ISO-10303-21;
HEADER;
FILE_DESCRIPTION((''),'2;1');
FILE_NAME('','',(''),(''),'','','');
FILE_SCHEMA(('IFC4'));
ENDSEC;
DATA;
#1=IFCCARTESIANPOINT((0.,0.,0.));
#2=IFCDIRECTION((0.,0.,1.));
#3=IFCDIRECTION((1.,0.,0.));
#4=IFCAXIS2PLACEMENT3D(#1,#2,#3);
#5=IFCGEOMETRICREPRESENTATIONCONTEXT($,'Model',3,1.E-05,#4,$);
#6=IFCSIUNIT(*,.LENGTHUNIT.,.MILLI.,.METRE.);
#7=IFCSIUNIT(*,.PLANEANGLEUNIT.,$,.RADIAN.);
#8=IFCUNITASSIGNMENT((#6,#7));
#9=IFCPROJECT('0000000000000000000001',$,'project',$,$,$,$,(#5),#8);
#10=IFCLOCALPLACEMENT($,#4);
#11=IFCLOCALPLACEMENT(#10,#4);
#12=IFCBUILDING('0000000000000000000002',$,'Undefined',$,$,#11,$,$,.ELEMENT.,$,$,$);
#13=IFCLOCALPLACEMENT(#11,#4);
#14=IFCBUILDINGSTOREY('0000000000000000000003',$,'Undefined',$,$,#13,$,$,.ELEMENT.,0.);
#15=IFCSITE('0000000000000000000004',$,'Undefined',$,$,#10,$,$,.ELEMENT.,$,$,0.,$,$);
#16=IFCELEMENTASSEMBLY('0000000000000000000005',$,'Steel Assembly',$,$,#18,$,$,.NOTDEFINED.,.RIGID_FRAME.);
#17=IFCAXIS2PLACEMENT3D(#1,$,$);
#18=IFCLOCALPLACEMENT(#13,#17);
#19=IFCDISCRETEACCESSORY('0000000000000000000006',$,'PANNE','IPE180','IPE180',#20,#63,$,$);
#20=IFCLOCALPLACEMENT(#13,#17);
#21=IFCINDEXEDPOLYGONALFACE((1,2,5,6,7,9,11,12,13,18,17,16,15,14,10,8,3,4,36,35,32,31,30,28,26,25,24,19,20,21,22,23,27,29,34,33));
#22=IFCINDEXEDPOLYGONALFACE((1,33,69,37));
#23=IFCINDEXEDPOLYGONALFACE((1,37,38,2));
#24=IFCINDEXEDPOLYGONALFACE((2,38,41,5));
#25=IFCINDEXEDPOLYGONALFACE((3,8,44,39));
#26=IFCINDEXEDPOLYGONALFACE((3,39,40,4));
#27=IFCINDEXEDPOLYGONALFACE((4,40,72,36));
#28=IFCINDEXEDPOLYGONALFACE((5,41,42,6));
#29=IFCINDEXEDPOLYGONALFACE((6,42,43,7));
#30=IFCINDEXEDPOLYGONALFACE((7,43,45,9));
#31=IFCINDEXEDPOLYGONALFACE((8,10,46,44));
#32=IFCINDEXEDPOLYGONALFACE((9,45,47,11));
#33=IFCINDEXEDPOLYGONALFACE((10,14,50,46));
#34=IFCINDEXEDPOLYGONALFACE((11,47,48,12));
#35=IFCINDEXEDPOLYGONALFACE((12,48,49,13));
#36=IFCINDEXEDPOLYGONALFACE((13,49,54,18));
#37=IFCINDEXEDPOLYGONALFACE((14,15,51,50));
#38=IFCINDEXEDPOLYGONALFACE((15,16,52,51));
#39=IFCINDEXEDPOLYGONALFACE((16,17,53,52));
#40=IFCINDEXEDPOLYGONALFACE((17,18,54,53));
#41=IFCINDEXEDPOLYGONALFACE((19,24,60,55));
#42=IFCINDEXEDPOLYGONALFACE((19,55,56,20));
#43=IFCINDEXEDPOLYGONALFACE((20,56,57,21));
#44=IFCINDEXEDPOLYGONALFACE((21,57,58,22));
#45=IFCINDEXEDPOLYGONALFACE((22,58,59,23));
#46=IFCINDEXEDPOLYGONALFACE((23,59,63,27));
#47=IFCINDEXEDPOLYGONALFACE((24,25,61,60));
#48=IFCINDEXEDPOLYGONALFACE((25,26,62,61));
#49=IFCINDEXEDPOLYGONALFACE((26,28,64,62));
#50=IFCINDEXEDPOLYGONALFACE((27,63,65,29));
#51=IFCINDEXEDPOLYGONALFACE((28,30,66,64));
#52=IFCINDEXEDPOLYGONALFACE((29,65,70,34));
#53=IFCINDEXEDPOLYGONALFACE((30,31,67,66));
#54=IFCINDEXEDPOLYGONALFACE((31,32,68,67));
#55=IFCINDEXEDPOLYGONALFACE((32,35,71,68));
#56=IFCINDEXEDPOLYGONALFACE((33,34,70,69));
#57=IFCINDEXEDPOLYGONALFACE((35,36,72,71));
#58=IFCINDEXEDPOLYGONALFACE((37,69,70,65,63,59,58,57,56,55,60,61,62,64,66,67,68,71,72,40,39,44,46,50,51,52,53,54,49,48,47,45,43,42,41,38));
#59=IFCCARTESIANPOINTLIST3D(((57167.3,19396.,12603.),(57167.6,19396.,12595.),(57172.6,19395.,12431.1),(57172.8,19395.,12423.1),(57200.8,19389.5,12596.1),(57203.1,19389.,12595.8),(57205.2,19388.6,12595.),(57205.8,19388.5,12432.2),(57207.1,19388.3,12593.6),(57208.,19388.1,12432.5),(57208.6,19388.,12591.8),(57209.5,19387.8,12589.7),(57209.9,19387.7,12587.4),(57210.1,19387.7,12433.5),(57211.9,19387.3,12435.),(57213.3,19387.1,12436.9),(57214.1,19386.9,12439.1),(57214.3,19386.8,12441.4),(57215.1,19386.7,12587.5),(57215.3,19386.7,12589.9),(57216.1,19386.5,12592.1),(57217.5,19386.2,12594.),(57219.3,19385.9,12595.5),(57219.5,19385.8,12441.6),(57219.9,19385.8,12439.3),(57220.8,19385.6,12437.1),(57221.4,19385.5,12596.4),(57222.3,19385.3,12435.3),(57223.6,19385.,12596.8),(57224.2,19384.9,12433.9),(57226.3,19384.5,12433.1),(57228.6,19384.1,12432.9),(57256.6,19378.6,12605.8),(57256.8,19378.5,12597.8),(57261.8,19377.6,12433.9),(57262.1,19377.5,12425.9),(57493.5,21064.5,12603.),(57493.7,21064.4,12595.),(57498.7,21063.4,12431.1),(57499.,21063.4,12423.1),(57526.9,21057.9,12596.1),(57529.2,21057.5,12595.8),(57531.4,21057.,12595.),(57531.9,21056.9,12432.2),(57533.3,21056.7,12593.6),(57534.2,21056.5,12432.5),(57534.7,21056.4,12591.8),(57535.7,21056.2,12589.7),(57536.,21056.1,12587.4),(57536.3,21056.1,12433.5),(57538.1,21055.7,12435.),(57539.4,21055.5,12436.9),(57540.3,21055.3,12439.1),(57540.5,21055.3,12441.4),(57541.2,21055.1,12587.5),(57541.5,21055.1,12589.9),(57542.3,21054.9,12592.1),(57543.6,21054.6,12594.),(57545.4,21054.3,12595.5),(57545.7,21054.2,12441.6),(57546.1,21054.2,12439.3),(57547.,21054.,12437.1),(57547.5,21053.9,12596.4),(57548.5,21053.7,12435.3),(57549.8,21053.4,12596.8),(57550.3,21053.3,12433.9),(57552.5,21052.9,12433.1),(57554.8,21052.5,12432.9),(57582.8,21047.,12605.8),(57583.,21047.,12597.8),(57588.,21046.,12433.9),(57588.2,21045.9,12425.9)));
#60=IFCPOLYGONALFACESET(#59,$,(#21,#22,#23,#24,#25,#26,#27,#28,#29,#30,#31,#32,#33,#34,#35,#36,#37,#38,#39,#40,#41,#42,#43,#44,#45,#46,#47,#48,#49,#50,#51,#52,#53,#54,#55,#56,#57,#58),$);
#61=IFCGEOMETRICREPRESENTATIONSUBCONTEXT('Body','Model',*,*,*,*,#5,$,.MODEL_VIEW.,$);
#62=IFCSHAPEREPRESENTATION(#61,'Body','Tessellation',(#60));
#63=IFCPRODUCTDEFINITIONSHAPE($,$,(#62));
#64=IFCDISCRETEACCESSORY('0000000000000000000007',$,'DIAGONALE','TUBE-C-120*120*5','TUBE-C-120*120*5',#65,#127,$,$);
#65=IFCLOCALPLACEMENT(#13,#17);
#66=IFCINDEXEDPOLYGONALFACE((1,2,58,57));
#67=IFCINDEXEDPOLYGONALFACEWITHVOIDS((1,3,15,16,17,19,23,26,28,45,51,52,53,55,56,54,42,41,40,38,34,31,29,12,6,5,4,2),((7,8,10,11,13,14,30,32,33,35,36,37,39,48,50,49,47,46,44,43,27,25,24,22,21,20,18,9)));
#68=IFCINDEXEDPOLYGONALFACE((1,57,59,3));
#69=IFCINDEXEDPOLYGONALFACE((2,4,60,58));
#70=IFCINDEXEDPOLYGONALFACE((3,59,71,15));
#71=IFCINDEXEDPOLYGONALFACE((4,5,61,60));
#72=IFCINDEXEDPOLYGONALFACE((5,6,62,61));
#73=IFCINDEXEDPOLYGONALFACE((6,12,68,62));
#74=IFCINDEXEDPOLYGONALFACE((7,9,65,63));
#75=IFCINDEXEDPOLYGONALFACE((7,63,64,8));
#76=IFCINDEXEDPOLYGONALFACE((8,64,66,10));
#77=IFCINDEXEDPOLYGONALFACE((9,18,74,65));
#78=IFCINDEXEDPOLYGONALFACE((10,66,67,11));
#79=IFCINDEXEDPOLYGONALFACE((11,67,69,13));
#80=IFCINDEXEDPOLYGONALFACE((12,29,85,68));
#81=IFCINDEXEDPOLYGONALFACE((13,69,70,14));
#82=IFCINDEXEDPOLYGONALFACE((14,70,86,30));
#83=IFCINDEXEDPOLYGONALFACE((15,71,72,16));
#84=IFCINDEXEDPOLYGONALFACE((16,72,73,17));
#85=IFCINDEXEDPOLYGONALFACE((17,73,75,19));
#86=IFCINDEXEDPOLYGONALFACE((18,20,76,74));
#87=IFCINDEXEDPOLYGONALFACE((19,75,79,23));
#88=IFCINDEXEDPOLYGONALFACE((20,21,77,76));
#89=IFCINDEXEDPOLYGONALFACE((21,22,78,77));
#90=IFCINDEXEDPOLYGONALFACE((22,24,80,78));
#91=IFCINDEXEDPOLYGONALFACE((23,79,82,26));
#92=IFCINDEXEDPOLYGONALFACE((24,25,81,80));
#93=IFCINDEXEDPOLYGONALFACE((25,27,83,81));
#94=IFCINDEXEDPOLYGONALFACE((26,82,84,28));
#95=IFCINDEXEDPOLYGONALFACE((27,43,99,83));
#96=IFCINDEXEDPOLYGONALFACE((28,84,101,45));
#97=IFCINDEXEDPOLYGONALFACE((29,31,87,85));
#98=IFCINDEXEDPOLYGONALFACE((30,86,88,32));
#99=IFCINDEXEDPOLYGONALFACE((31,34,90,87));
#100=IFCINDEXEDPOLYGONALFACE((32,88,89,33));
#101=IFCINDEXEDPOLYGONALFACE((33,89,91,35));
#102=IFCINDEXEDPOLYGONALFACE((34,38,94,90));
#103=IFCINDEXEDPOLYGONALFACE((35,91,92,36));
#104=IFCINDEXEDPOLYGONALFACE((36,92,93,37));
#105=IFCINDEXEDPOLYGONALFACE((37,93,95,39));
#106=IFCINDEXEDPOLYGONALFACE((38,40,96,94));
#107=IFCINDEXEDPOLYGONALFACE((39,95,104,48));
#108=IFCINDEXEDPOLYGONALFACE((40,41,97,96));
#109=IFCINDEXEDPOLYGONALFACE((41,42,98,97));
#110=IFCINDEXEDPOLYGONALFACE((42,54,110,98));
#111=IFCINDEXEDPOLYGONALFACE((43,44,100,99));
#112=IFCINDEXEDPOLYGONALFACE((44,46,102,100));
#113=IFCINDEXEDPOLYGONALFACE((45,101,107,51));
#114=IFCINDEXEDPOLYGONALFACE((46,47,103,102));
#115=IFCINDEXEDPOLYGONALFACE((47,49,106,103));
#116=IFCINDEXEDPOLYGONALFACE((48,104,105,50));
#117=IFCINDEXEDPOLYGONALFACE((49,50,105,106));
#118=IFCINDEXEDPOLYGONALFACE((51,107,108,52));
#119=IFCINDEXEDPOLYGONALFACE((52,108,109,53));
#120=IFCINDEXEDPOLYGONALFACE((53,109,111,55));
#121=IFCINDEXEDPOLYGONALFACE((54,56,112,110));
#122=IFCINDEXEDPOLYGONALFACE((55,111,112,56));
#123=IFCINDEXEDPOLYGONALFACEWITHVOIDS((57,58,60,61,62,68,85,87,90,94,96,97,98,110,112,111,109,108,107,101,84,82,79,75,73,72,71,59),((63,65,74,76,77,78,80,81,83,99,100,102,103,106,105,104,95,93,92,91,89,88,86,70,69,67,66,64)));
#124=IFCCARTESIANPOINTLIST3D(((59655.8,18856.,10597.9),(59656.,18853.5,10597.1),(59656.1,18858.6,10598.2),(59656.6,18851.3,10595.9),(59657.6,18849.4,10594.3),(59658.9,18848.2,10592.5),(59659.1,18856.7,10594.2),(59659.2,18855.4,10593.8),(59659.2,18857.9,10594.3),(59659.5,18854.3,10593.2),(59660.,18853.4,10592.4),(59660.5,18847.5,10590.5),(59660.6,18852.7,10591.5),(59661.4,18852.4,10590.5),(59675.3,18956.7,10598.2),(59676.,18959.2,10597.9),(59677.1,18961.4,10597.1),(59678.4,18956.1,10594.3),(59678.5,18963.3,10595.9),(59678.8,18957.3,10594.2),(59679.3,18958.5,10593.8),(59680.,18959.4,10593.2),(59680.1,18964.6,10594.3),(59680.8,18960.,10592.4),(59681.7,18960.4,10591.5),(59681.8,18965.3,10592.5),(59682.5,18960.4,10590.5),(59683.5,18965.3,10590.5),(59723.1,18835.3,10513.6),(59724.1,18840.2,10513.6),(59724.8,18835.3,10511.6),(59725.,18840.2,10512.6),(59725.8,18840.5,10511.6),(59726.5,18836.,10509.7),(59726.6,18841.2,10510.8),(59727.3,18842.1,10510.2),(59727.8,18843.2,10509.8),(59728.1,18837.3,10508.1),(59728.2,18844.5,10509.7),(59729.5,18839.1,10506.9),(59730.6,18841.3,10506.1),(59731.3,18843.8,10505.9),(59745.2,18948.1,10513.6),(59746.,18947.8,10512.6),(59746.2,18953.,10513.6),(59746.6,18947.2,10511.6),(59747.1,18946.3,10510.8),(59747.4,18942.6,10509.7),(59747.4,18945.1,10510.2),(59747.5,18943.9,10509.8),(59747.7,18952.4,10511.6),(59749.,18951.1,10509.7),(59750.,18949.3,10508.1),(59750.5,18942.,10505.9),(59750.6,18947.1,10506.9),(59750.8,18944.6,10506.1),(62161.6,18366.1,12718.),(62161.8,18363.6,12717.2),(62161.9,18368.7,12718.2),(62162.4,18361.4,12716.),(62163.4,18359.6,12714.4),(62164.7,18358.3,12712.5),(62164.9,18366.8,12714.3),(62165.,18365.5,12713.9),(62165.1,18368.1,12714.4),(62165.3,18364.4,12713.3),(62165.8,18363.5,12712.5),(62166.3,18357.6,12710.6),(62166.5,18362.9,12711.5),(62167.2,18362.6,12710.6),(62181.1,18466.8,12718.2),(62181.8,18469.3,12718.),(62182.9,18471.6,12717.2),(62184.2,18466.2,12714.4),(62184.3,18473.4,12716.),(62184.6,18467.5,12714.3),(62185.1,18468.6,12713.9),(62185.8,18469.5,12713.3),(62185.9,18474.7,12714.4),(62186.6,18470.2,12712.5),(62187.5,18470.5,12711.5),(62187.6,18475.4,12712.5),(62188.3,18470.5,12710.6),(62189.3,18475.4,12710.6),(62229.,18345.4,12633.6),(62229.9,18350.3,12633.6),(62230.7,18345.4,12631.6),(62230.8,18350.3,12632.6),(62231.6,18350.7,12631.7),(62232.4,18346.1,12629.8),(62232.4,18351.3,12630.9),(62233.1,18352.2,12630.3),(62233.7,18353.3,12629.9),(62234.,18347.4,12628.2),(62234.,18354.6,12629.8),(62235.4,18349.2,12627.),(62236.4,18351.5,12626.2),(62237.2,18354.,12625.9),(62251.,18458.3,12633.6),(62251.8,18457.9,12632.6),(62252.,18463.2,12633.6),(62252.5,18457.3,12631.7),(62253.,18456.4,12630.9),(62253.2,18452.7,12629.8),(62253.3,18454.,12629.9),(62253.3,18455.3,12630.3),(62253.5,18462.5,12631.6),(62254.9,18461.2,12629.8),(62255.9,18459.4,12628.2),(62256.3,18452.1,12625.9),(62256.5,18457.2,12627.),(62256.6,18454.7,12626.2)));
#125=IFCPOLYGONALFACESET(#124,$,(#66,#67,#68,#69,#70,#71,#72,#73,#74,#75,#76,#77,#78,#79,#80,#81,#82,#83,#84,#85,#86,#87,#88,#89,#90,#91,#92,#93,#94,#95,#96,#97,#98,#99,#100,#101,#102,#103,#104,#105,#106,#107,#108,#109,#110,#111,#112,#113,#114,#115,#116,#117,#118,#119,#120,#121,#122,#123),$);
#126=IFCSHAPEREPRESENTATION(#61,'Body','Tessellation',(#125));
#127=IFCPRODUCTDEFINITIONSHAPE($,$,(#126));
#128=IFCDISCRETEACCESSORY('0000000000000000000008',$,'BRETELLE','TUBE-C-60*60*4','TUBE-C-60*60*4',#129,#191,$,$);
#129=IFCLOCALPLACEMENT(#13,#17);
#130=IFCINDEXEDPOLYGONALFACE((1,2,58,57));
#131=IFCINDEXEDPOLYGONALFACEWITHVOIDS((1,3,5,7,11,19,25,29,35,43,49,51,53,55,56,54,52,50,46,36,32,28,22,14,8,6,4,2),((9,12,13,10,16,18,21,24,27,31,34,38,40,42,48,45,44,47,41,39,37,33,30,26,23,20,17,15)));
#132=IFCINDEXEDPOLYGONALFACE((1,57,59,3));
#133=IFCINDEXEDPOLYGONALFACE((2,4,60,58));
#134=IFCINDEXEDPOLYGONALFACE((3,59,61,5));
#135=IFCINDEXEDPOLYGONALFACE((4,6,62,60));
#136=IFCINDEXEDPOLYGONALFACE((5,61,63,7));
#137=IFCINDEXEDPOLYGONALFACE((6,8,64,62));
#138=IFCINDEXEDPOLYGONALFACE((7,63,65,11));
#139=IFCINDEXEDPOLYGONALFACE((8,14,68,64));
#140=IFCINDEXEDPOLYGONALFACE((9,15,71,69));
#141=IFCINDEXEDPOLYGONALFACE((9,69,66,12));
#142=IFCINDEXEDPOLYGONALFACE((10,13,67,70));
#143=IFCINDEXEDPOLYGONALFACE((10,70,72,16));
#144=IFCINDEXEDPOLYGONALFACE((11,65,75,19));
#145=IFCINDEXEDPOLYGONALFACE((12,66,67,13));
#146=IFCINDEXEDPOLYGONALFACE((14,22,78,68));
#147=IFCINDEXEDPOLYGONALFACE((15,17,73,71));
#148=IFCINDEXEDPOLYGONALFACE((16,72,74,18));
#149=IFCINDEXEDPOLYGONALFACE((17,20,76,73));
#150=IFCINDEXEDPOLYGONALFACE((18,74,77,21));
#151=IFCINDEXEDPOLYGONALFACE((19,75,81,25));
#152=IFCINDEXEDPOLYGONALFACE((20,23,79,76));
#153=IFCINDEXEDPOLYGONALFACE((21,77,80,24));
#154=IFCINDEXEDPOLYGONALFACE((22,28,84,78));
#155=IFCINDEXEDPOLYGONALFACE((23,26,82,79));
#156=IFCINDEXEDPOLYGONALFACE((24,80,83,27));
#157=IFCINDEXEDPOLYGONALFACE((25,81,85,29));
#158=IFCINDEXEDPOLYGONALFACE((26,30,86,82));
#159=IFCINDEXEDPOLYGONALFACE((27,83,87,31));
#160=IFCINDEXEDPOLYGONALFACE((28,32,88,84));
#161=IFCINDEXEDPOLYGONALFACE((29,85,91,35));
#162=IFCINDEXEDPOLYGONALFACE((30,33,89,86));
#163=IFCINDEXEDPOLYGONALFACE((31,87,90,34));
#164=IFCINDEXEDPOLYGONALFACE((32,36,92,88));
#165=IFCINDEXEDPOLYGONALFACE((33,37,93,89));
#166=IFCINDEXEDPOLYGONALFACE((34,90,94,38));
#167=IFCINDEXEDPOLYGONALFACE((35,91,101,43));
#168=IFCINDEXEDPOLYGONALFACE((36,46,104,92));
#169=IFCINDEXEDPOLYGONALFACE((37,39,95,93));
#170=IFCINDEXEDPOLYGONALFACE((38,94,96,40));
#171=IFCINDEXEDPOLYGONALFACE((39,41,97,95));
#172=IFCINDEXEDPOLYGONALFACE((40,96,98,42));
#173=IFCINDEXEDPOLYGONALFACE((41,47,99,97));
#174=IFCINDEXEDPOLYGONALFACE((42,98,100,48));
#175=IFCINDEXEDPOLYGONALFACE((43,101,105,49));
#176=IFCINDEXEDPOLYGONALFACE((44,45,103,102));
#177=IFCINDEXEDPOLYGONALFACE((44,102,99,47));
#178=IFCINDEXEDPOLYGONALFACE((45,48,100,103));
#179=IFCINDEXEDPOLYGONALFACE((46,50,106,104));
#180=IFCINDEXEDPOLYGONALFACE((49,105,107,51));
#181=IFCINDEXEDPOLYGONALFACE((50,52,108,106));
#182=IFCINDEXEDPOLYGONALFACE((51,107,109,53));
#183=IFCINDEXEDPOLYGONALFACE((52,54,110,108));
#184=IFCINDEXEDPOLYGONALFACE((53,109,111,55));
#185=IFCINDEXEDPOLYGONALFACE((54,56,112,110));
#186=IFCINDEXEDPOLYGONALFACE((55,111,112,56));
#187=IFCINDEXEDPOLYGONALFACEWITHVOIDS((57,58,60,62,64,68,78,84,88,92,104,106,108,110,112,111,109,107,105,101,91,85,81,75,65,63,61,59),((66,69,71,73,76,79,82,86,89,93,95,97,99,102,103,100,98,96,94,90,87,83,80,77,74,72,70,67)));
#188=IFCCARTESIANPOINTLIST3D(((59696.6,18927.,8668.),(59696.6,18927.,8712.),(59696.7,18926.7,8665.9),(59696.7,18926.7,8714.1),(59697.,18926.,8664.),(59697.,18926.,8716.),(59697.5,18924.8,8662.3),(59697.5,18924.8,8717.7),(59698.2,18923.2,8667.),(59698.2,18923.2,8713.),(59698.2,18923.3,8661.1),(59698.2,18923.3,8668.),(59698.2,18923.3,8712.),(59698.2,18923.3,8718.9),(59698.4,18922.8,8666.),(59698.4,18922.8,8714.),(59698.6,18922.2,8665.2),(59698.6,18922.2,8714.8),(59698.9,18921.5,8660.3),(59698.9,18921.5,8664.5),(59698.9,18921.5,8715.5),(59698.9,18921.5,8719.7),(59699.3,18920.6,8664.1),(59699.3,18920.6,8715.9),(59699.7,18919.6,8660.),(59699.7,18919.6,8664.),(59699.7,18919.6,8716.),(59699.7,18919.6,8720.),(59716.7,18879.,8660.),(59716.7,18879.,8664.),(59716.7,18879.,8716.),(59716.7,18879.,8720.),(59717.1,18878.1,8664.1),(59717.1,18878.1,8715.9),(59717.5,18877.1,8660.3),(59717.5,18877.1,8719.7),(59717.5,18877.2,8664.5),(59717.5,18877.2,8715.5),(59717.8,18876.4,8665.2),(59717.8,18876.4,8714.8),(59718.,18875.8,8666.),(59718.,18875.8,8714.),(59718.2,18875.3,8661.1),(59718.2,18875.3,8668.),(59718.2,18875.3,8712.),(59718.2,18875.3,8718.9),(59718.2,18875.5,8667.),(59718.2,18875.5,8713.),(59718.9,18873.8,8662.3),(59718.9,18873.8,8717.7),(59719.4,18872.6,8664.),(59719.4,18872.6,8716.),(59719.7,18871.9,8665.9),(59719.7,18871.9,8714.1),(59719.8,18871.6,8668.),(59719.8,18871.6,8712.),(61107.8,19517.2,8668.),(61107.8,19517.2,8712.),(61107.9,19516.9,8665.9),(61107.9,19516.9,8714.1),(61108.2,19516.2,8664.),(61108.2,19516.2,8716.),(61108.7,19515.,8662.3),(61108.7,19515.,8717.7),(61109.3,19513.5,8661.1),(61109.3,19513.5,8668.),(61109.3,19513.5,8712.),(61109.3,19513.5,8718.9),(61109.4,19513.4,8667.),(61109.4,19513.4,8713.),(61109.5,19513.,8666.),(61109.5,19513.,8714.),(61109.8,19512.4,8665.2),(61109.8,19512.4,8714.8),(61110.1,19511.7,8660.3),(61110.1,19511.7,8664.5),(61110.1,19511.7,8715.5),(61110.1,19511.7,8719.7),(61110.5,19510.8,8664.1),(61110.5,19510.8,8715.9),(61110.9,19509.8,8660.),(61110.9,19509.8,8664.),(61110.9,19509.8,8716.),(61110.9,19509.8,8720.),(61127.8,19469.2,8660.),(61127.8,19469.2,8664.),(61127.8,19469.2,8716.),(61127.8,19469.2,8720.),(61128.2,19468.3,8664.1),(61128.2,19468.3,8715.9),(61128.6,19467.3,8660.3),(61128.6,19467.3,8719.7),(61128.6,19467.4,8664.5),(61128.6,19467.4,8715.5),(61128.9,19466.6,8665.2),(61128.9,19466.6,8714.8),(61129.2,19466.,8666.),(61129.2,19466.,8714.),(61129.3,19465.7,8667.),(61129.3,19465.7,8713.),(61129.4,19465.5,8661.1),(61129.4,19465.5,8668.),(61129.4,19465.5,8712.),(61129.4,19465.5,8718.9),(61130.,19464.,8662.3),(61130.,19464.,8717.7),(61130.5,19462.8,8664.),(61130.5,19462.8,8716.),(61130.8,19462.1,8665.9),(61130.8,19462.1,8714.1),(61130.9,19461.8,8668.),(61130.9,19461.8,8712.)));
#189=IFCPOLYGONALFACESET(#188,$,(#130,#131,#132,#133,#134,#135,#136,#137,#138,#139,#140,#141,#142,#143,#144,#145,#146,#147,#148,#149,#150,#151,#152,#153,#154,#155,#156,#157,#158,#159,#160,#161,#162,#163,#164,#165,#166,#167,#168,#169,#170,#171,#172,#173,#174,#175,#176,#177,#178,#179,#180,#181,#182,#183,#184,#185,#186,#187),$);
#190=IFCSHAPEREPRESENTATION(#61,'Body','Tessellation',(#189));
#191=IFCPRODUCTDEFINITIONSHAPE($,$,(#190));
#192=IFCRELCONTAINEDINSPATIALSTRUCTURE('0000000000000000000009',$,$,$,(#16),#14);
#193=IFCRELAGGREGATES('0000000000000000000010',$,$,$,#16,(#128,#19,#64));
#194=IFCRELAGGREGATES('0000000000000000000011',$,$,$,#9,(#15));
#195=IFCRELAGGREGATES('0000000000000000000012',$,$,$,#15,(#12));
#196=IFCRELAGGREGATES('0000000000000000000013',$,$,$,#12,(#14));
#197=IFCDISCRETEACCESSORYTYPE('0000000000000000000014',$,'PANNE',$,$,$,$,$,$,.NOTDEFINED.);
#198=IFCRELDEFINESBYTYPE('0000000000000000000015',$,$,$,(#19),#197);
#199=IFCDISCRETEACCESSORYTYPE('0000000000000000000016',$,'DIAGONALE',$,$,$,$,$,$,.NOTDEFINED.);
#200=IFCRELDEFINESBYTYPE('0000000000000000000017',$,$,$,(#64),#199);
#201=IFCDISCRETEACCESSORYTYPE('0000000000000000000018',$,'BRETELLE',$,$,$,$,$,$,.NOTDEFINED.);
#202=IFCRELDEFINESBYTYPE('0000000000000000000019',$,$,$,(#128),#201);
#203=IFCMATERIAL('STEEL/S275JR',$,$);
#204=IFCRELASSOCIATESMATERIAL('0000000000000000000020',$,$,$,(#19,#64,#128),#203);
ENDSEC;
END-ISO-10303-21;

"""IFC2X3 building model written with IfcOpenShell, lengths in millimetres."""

from ifc_helpers import new_model, si_unit, frame, origin_with_axes, origin_2d_with_axis, place, context, subcontext, project, spatial, hollow_rectangle, i_section, extrude, material, type_object, element, aggregate, save


model = new_model("IFC2X3")

# Units and contexts
model_context = context("Model", 3, precision=1e-05, world=origin_with_axes())
body_context = subcontext(model_context, "Body", "Model", "MODEL_VIEW")
ifc_project = project(units=[si_unit("LENGTHUNIT", "METRE", prefix="MILLI"), si_unit("PLANEANGLEUNIT", "RADIAN")], contexts=[model_context])

# Site, building, storey
site_placement = place(None, origin_with_axes())
site = spatial("IfcSite", under=ifc_project, at=site_placement, Name="Undefined", CompositionType="ELEMENT", RefElevation=0.0)
building_placement = place(site_placement, origin_with_axes())
building = spatial("IfcBuilding", under=site, at=building_placement, Name="Undefined", CompositionType="ELEMENT")
storey_placement = place(building_placement, origin_with_axes())
storey = spatial("IfcBuildingStorey", under=building, at=storey_placement, Name="Undefined", CompositionType="ELEMENT", Elevation=0.0)

# Shared definitions
ifc_material_1 = material(Name="STEEL/S275JR")

# Element assembly, discrete accessories
assembly_1_placement = place(storey_placement, origin_with_axes())
assembly_1 = element("IfcElementAssembly", 1, at=assembly_1_placement, inside=storey, Name="Steel Assembly", AssemblyPlace="NOTDEFINED", PredefinedType="RIGID_FRAME")
discrete_accessory_type_1 = type_object("IfcDiscreteAccessoryType", Name="PANNE")
discrete_accessory_1_placement = place(assembly_1_placement, frame((57214.7, 19386.8, 12514.5), z_axis=(-0.030408, 0.005945, 0.99952), x_axis=(0.191859, 0.981422, 0.0)))
discrete_accessory_1 = element("IfcDiscreteAccessory", 2, at=discrete_accessory_1_placement, type_object=discrete_accessory_type_1, material=ifc_material_1, Name="PANNE", Description="IPE180", ObjectType="IPE180", context=body_context, shape_type="SweptSolid", body=[
    extrude(i_section(OverallWidth=91.0, OverallDepth=180.0, WebThickness=5.3, FlangeThickness=8.0, FilletRadius=9.0, at=origin_2d_with_axis()), frame((1700.0, 0.0, 0.0), z_axis=(-1.0, 0.0, 0.0), x_axis=(0.0, -1.0, 0.0)), (0.0, 0.0, 1.0), 1700.0),
])
discrete_accessory_type_2 = type_object("IfcDiscreteAccessoryType", Name="DIAGONALE")
discrete_accessory_2_placement = place(assembly_1_placement, frame((59703.3, 18900.3, 10552.0), z_axis=(0.626956, -0.122564, -0.769353), x_axis=(0.75506, -0.147608, 0.638824)))
discrete_accessory_2 = element("IfcDiscreteAccessory", 3, at=discrete_accessory_2_placement, type_object=discrete_accessory_type_2, material=ifc_material_1, Name="DIAGONALE", Description="TUBE-C-120*120*5", ObjectType="TUBE-C-120*120*5", context=body_context, shape_type="SweptSolid", body=[
    extrude(hollow_rectangle(XDim=120.0, YDim=120.0, WallThickness=5.0, InnerFilletRadius=5.0, OuterFilletRadius=10.0, at=origin_2d_with_axis()), frame((3318.7, 0.0, 0.0), z_axis=(-1.0, 0.0, 0.0), x_axis=(0.0, -1.0, 0.0)), (0.0, 0.0, 1.0), 3318.7),
])
discrete_accessory_type_3 = type_object("IfcDiscreteAccessoryType", Name="BRETELLE")
discrete_accessory_3_placement = place(assembly_1_placement, frame((61119.4, 19489.5, 8690.0), z_axis=(-0.385851, 0.922561, 0.0), x_axis=(-0.922561, -0.385851, 0.0)))
discrete_accessory_3 = element("IfcDiscreteAccessory", 4, at=discrete_accessory_3_placement, type_object=discrete_accessory_type_3, material=ifc_material_1, Name="BRETELLE", Description="TUBE-C-60*60*4", ObjectType="TUBE-C-60*60*4", context=body_context, shape_type="SweptSolid", body=[
    extrude(hollow_rectangle(XDim=60.0, YDim=60.0, WallThickness=4.0, InnerFilletRadius=4.0, OuterFilletRadius=8.0, at=origin_2d_with_axis()), frame((1529.6, 0.0, 0.0), z_axis=(-1.0, 0.0, 0.0), x_axis=(0.0, -1.0, 0.0)), (0.0, 0.0, 1.0), 1529.6),
])
aggregate(assembly_1, [discrete_accessory_3, discrete_accessory_1, discrete_accessory_2])

save(model, "model.ifc")
